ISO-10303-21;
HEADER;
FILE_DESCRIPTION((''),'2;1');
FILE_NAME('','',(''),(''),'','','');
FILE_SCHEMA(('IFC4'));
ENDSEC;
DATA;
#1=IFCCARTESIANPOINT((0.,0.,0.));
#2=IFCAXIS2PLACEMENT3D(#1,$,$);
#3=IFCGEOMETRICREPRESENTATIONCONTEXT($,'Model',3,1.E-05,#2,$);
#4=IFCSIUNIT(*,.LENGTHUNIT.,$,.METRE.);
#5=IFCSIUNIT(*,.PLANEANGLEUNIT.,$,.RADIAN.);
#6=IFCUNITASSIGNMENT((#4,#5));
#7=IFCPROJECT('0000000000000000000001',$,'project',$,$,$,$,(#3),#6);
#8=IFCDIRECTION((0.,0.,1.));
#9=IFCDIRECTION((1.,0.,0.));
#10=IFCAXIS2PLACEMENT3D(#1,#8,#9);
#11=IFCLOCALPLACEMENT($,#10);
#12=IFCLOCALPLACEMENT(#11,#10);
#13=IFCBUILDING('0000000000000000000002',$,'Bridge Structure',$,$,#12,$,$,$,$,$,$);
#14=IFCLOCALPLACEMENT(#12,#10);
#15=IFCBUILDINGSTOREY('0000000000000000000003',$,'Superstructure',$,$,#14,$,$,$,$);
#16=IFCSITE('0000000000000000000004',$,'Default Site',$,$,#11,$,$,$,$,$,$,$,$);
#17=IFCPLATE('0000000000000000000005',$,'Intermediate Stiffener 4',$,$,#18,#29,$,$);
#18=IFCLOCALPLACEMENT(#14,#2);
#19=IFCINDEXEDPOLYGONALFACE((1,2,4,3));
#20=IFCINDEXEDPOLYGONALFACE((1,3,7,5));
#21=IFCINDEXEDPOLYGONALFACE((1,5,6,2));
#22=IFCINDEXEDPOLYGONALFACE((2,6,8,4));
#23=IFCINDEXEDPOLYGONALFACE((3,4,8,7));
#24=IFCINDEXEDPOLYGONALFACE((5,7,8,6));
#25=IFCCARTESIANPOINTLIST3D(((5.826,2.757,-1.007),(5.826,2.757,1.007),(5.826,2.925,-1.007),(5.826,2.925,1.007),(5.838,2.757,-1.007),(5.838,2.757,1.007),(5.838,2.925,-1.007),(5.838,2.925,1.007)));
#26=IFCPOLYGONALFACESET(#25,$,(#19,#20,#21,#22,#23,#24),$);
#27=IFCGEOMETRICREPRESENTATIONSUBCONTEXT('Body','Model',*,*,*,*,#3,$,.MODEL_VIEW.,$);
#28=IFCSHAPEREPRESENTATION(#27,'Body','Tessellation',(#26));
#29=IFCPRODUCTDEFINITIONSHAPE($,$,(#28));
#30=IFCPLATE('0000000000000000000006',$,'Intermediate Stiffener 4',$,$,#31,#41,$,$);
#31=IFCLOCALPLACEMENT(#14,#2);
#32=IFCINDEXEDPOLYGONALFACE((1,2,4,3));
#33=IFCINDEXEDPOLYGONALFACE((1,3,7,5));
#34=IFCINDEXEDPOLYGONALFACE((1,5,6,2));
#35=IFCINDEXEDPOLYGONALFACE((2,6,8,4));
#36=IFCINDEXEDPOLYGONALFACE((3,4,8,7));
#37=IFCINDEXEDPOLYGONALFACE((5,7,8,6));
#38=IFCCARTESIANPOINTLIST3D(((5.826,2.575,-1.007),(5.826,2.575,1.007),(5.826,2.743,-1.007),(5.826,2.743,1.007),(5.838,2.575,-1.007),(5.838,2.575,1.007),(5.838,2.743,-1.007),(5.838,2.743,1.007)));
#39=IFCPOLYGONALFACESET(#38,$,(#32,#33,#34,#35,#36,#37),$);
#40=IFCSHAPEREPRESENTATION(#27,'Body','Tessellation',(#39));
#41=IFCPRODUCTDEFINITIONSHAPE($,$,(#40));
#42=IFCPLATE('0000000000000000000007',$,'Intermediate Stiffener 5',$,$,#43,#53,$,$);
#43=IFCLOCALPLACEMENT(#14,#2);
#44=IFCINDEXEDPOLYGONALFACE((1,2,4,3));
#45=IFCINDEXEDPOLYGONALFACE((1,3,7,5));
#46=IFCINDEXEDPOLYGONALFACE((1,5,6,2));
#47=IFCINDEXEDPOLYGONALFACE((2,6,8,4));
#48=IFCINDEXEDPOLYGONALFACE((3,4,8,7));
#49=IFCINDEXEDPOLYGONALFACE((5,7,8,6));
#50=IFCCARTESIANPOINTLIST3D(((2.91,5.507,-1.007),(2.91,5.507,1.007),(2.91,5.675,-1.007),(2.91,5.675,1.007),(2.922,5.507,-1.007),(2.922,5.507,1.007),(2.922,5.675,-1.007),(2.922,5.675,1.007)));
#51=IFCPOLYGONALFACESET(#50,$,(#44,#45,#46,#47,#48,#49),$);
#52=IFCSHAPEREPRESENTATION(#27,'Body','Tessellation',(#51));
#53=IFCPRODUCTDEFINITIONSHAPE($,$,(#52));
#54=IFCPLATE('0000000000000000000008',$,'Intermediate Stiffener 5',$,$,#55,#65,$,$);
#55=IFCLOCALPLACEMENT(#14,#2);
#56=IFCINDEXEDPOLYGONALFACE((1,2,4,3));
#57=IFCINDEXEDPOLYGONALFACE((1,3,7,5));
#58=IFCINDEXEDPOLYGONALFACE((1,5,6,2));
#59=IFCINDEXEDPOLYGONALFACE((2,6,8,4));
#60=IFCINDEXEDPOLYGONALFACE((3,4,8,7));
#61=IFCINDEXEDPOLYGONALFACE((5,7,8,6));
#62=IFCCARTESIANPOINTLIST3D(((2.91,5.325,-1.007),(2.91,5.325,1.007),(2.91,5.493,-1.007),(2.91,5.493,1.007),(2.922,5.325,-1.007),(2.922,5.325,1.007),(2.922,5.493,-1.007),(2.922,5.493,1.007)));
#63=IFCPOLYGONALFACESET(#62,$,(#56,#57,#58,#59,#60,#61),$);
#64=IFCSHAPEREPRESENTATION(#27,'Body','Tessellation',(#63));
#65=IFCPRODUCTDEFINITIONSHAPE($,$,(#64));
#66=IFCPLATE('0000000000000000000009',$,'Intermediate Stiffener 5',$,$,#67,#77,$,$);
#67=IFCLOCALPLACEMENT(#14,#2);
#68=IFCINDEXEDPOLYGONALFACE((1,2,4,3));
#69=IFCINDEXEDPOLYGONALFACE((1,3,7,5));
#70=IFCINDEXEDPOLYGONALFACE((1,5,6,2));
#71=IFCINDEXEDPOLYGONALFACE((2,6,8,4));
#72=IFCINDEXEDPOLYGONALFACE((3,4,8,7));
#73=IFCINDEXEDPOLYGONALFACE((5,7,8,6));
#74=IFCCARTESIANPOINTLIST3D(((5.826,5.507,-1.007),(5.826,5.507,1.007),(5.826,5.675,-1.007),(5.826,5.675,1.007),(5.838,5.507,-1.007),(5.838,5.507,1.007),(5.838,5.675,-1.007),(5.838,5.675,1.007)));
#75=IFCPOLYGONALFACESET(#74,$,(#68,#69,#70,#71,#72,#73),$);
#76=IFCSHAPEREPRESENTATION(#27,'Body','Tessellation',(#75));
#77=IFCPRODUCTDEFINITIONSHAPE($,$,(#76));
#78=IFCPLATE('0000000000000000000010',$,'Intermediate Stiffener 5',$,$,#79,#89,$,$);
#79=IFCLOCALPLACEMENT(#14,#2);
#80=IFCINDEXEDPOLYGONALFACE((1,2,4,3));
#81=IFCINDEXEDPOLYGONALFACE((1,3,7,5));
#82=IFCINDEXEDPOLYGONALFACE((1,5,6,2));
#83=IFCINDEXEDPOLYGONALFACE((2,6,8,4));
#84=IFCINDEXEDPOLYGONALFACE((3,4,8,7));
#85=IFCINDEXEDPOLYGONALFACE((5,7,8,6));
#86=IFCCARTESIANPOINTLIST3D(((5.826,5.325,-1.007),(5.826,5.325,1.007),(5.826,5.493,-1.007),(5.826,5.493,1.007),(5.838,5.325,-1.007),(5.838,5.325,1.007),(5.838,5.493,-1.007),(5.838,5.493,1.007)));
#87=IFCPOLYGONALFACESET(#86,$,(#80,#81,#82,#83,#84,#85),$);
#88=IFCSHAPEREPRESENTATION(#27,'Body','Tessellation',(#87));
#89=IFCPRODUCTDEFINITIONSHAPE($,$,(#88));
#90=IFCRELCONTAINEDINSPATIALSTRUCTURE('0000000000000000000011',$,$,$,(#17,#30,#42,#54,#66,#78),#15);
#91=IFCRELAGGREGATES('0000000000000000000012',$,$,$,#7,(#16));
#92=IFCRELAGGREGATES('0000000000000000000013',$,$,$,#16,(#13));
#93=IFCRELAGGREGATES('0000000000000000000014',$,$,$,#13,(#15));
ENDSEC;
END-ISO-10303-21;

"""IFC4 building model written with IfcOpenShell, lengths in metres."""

from ifc_helpers import new_model, si_unit, frame, origin, origin_with_axes, origin_2d_with_axis, place, context, subcontext, project, spatial, rectangle, extrude, element, save


model = new_model("IFC4")

# Units and contexts
model_context = context("Model", 3, precision=1e-05, world=origin())
body_context = subcontext(model_context, "Body", "Model", "MODEL_VIEW")
ifc_project = project(units=[si_unit("LENGTHUNIT", "METRE"), si_unit("PLANEANGLEUNIT", "RADIAN")], contexts=[model_context])

# Site, building, storey
site_placement = place(None, origin_with_axes())
site = spatial("IfcSite", under=ifc_project, at=site_placement, Name="Default Site")
building_placement = place(site_placement, origin_with_axes())
building = spatial("IfcBuilding", under=site, at=building_placement, Name="Bridge Structure")
storey_placement = place(building_placement, origin_with_axes())
storey = spatial("IfcBuildingStorey", under=building, at=storey_placement, Name="Superstructure")

# Plates
for number, where, z_axis, x_axis, name in (
    (1, (5.832, 2.841, -1.007), (0.0, 0.0, 1.0), (1.0, 0.0, 0.0), "Intermediate Stiffener 4"),
    (2, (5.832, 2.659, -1.007), (0.0, 0.0, 1.0), (1.0, 0.0, 0.0), "Intermediate Stiffener 4"),
    (3, (2.916, 5.591, -1.007), (0.0, 0.0, 1.0), (1.0, 0.0, 0.0), "Intermediate Stiffener 5"),
    (4, (2.916, 5.409, -1.007), (0.0, 0.0, 1.0), (1.0, 0.0, 0.0), "Intermediate Stiffener 5"),
    (5, (5.832, 5.591, -1.007), (0.0, 0.0, 1.0), (1.0, 0.0, 0.0), "Intermediate Stiffener 5"),
    (6, (5.832, 5.409, -1.007), (0.0, 0.0, 1.0), (1.0, 0.0, 0.0), "Intermediate Stiffener 5"),
):
    element("IfcPlate", number, at=place(storey_placement, frame(where, z_axis=z_axis, x_axis=x_axis)), inside=storey, Name=name, context=body_context, shape_type="SweptSolid", body=[
        extrude(rectangle(XDim=0.012, YDim=0.168, at=origin_2d_with_axis()), origin_with_axes(), (0.0, 0.0, 1.0), 2.014),
    ])

save(model, "model.ifc")
